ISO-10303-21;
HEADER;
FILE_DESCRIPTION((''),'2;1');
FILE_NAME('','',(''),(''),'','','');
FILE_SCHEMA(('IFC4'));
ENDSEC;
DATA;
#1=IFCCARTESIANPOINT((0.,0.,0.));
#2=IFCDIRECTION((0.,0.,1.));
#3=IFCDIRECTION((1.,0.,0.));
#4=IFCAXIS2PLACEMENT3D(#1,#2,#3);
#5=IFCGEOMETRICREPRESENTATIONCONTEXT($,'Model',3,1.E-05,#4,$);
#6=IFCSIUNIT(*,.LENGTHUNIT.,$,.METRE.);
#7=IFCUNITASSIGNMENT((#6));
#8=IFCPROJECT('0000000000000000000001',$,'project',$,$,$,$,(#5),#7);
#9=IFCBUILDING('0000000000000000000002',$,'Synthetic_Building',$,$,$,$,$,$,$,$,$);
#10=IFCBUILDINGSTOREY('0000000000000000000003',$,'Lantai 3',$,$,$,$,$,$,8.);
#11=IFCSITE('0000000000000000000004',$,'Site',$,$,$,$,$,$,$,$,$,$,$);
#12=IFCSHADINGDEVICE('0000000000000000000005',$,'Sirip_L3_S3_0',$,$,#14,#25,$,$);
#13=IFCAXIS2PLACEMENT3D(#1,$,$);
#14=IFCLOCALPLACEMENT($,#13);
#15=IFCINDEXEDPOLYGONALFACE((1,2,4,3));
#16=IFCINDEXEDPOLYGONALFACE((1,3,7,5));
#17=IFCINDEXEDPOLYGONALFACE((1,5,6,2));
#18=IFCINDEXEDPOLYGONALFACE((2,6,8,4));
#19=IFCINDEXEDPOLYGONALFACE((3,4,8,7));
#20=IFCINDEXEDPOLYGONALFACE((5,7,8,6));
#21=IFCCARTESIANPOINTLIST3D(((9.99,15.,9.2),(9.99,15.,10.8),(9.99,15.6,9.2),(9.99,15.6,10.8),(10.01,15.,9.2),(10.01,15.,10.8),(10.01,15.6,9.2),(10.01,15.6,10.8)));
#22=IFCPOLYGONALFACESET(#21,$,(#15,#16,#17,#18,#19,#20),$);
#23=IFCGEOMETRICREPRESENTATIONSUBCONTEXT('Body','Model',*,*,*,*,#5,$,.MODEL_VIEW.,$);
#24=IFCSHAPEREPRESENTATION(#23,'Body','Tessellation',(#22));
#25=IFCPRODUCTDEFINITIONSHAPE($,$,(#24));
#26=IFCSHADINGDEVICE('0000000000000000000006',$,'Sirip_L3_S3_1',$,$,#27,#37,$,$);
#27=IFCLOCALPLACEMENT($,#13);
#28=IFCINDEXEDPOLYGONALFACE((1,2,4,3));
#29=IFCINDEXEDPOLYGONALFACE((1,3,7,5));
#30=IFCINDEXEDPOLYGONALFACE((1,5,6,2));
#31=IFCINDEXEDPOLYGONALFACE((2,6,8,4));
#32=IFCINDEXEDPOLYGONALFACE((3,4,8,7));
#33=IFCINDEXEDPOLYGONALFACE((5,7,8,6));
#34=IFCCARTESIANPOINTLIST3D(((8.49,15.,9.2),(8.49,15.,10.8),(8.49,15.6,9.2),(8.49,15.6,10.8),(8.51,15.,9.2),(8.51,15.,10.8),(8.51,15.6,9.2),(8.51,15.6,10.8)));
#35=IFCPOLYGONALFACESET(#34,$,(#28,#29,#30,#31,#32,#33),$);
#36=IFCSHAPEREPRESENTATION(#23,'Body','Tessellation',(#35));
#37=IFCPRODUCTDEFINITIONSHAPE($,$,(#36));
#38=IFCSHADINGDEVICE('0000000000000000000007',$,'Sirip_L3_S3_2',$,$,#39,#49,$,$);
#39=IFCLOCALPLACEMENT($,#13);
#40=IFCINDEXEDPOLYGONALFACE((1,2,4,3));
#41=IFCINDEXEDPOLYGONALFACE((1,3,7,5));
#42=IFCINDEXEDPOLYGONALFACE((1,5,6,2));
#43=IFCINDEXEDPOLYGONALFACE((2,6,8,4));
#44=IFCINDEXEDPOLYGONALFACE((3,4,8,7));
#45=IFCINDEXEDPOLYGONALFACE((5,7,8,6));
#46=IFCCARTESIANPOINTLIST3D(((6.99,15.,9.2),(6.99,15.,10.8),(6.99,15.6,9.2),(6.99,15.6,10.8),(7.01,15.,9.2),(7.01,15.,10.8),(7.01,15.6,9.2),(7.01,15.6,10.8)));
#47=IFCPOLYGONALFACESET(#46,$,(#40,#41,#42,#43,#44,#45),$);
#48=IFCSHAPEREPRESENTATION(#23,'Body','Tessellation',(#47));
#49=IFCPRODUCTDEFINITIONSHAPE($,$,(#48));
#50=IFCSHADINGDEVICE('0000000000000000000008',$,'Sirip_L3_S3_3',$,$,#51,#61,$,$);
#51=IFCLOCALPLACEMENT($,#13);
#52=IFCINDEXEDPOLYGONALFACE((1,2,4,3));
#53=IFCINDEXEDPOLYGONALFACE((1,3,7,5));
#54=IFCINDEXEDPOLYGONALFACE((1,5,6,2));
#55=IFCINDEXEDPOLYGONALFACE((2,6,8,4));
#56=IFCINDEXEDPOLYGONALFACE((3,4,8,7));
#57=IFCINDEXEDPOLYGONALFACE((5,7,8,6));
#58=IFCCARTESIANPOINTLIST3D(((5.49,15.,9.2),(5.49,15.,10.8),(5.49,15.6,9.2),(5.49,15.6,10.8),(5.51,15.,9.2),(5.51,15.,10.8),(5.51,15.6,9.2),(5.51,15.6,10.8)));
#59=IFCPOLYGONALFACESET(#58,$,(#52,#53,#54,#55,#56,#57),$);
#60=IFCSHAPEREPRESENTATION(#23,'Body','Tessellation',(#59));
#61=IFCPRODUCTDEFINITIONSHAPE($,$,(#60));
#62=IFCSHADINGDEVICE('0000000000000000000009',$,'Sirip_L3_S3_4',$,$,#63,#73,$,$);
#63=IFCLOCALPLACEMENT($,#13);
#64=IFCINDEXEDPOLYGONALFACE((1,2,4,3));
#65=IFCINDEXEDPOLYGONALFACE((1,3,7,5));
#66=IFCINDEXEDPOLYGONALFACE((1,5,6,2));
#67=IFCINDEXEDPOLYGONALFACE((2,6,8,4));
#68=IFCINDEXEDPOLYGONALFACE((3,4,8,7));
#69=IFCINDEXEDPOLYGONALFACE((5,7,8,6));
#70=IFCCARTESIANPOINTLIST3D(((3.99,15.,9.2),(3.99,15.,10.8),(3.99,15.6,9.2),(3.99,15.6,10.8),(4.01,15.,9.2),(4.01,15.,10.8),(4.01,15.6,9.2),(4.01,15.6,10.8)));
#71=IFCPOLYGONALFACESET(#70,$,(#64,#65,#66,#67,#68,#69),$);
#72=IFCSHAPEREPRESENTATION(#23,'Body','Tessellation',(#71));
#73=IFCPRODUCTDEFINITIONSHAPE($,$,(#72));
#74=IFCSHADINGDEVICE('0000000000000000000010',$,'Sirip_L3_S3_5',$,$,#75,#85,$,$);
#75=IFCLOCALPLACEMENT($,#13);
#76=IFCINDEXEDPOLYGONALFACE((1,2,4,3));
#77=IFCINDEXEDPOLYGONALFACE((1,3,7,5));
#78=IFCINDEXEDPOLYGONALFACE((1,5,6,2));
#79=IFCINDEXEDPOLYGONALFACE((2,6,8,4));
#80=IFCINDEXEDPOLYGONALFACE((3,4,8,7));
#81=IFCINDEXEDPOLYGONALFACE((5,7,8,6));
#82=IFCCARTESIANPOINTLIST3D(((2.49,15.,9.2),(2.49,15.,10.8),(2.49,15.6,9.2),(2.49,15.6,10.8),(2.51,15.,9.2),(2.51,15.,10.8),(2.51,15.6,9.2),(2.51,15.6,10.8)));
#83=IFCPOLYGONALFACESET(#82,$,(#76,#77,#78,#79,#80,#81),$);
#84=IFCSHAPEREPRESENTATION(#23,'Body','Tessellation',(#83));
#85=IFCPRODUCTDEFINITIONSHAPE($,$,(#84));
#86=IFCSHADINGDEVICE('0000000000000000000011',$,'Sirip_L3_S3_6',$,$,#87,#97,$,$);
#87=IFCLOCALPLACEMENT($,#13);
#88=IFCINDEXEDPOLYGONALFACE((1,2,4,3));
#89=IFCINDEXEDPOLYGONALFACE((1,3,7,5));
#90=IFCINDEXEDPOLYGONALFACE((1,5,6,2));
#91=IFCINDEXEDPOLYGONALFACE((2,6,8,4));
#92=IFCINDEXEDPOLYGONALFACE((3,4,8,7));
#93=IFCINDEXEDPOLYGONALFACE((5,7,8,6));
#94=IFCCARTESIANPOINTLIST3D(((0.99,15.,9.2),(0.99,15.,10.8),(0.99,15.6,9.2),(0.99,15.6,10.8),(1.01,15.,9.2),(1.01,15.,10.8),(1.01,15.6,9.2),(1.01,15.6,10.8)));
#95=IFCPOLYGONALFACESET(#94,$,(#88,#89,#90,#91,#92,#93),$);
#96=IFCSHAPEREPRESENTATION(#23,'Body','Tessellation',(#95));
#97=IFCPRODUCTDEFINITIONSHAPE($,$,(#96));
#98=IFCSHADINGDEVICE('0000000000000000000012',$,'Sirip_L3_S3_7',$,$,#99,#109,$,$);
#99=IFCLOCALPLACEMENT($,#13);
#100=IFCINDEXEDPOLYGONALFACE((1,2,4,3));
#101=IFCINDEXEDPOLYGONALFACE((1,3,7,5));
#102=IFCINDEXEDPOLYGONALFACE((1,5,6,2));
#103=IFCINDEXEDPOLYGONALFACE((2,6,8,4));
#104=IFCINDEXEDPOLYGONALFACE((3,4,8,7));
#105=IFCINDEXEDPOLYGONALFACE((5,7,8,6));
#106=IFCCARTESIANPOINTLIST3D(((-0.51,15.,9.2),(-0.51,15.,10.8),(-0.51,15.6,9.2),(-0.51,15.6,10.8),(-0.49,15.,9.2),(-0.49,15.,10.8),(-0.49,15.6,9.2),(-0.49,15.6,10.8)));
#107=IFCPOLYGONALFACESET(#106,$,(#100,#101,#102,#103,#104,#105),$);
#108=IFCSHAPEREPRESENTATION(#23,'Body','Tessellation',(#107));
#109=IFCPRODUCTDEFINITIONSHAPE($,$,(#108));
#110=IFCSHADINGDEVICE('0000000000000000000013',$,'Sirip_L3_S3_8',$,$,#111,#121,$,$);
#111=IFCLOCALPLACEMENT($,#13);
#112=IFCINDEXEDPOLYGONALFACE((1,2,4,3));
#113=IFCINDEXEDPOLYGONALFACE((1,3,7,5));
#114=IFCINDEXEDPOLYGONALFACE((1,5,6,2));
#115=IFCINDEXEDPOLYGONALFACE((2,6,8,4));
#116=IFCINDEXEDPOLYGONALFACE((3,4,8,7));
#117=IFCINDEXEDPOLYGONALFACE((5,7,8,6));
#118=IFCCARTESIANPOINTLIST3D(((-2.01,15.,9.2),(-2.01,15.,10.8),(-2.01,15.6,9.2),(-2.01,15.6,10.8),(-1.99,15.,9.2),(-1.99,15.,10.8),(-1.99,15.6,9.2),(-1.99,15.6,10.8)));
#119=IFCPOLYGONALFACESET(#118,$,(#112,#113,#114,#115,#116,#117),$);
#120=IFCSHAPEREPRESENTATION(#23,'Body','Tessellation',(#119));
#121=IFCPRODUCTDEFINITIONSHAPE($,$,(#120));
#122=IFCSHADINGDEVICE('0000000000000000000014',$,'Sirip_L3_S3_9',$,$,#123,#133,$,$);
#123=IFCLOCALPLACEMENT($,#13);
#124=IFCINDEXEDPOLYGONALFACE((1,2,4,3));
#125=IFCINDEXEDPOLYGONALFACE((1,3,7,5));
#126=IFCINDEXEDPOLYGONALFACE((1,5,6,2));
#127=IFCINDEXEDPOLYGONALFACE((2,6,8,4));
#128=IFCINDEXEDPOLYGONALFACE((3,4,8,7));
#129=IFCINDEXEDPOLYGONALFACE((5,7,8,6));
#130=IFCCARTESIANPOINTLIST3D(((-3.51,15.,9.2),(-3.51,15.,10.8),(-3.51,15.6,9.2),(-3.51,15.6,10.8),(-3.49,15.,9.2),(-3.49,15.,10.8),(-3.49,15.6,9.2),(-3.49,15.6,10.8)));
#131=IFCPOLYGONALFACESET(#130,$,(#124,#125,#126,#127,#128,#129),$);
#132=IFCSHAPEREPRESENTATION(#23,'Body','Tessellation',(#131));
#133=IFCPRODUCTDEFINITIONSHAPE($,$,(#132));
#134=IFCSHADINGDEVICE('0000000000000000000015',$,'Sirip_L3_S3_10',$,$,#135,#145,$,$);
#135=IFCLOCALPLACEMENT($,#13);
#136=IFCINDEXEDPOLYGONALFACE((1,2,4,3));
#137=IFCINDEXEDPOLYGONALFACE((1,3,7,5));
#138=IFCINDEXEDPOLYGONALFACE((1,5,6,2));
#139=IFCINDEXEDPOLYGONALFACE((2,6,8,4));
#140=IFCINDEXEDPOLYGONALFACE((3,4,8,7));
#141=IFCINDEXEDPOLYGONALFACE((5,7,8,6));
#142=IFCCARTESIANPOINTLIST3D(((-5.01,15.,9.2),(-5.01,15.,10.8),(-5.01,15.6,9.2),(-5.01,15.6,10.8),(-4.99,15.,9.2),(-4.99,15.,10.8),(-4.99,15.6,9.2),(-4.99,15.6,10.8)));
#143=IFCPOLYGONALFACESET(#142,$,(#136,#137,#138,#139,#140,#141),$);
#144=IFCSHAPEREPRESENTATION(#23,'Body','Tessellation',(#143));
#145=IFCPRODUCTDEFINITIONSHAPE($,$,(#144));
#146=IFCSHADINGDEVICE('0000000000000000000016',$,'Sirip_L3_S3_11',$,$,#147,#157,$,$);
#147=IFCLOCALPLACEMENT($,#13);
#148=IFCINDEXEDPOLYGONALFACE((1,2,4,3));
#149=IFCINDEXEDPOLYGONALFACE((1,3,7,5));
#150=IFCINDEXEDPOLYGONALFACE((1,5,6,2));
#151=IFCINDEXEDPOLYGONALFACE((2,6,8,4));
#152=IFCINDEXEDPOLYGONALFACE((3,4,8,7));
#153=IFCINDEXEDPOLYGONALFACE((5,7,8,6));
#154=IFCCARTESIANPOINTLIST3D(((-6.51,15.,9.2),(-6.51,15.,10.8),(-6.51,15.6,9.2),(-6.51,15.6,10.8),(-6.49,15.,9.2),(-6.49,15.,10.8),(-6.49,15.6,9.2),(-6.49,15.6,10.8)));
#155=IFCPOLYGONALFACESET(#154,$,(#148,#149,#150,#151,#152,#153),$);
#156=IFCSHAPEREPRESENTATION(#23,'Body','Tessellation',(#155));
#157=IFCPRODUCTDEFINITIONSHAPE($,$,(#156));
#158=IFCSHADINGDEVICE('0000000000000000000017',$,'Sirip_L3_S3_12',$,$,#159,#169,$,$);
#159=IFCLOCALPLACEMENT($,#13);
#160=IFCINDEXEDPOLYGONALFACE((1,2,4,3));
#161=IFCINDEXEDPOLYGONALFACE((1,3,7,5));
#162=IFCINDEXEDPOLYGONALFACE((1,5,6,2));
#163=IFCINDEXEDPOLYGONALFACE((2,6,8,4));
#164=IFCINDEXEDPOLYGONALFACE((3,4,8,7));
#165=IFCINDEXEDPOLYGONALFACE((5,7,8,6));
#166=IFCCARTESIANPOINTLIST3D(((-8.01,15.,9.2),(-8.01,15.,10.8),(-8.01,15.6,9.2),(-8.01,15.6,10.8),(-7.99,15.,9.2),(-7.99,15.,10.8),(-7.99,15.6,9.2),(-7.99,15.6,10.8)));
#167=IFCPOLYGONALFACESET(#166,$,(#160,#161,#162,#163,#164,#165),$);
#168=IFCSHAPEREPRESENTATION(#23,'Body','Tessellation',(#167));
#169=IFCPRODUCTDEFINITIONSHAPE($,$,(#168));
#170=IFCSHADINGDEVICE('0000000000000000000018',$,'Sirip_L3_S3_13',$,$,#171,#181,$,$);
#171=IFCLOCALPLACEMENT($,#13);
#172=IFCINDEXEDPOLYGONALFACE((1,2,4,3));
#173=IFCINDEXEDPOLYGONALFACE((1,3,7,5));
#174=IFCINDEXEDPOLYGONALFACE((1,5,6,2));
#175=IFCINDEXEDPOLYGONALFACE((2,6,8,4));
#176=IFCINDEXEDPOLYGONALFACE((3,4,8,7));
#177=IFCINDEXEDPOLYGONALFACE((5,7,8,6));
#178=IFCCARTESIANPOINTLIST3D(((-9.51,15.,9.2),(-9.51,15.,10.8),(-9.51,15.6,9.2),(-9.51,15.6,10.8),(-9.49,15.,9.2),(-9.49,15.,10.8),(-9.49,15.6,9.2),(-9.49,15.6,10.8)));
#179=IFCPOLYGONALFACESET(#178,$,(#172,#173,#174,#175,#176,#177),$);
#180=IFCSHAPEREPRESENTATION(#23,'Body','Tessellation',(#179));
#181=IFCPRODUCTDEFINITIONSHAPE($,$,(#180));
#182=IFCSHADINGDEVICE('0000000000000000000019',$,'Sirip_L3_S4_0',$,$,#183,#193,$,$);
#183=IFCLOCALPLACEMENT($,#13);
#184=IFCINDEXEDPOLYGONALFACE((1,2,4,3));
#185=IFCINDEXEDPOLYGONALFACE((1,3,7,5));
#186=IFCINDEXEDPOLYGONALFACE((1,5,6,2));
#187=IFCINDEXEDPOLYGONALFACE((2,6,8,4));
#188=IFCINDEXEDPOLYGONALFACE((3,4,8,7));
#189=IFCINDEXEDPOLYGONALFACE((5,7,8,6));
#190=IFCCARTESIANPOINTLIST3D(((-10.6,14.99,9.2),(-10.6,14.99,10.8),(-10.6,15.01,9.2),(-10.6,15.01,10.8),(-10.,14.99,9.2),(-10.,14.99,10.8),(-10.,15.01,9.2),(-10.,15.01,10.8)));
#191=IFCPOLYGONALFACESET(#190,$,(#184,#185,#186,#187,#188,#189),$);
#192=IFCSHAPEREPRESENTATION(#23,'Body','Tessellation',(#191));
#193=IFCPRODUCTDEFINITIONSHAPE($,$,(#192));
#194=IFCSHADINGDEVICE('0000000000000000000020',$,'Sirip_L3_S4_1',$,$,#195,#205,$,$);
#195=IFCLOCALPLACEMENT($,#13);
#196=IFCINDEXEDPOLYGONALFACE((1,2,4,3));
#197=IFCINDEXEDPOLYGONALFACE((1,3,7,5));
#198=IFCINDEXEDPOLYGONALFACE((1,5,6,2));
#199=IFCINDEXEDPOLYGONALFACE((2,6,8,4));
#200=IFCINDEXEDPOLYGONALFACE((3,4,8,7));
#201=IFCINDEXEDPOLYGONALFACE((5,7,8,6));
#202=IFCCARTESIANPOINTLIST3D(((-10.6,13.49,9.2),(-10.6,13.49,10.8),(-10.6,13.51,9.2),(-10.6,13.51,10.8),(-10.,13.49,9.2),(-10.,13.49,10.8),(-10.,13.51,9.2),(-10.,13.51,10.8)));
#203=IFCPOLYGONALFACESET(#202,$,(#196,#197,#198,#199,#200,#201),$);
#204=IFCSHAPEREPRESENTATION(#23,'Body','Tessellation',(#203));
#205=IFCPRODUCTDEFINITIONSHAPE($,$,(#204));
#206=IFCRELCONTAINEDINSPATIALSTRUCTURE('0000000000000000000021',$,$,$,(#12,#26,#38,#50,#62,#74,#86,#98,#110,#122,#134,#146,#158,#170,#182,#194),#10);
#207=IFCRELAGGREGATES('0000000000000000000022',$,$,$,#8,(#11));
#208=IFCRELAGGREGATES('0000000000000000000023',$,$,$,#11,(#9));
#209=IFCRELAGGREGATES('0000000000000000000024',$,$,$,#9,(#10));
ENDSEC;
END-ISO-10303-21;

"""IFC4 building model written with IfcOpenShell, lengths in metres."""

from ifc_helpers import new_model, si_unit, frame, origin_with_axes, place, context, subcontext, project, spatial, polyline, outline, extrude, element, save


model = new_model("IFC4")

# Units and contexts
model_context = context("Model", 3, precision=1e-05, world=origin_with_axes())
body_context = subcontext(model_context, "Body", "Model", "MODEL_VIEW")
ifc_project = project(units=[si_unit("LENGTHUNIT", "METRE")], contexts=[model_context])

# Site, building, storey
site = spatial("IfcSite", under=ifc_project, Name="Site")
building = spatial("IfcBuilding", under=site, Name="Synthetic_Building")
storey = spatial("IfcBuildingStorey", under=building, Name="Lantai 3", Elevation=8.0)

# Shading devices
shading_device_1_placement = place(None, origin_with_axes())
element("IfcShadingDevice", 1, at=shading_device_1_placement, inside=storey, Name="Sirip_L3_S3_0", context=body_context, shape_type="SweptSolid", body=[
    extrude(outline(polyline([(10.01, 15.0), (9.99, 15.0), (9.99, 15.6), (10.01, 15.6), (10.01, 15.0)])), frame((0.0, 0.0, 9.2), z_axis=(0.0, 0.0, 1.0), x_axis=(1.0, 0.0, 0.0)), (0.0, 0.0, 1.0), 1.6),
])
shading_device_2_placement = place(None, origin_with_axes())
element("IfcShadingDevice", 2, at=shading_device_2_placement, inside=storey, Name="Sirip_L3_S3_1", context=body_context, shape_type="SweptSolid", body=[
    extrude(outline(polyline([(8.51, 15.0), (8.49, 15.0), (8.49, 15.6), (8.51, 15.6), (8.51, 15.0)])), frame((0.0, 0.0, 9.2), z_axis=(0.0, 0.0, 1.0), x_axis=(1.0, 0.0, 0.0)), (0.0, 0.0, 1.0), 1.6),
])
shading_device_3_placement = place(None, origin_with_axes())
element("IfcShadingDevice", 3, at=shading_device_3_placement, inside=storey, Name="Sirip_L3_S3_2", context=body_context, shape_type="SweptSolid", body=[
    extrude(outline(polyline([(7.01, 15.0), (6.99, 15.0), (6.99, 15.6), (7.01, 15.6), (7.01, 15.0)])), frame((0.0, 0.0, 9.2), z_axis=(0.0, 0.0, 1.0), x_axis=(1.0, 0.0, 0.0)), (0.0, 0.0, 1.0), 1.6),
])
shading_device_4_placement = place(None, origin_with_axes())
element("IfcShadingDevice", 4, at=shading_device_4_placement, inside=storey, Name="Sirip_L3_S3_3", context=body_context, shape_type="SweptSolid", body=[
    extrude(outline(polyline([(5.51, 15.0), (5.49, 15.0), (5.49, 15.6), (5.51, 15.6), (5.51, 15.0)])), frame((0.0, 0.0, 9.2), z_axis=(0.0, 0.0, 1.0), x_axis=(1.0, 0.0, 0.0)), (0.0, 0.0, 1.0), 1.6),
])
shading_device_5_placement = place(None, origin_with_axes())
element("IfcShadingDevice", 5, at=shading_device_5_placement, inside=storey, Name="Sirip_L3_S3_4", context=body_context, shape_type="SweptSolid", body=[
    extrude(outline(polyline([(4.01, 15.0), (3.99, 15.0), (3.99, 15.6), (4.01, 15.6), (4.01, 15.0)])), frame((0.0, 0.0, 9.2), z_axis=(0.0, 0.0, 1.0), x_axis=(1.0, 0.0, 0.0)), (0.0, 0.0, 1.0), 1.6),
])
shading_device_6_placement = place(None, origin_with_axes())
element("IfcShadingDevice", 6, at=shading_device_6_placement, inside=storey, Name="Sirip_L3_S3_5", context=body_context, shape_type="SweptSolid", body=[
    extrude(outline(polyline([(2.51, 15.0), (2.49, 15.0), (2.49, 15.6), (2.51, 15.6), (2.51, 15.0)])), frame((0.0, 0.0, 9.2), z_axis=(0.0, 0.0, 1.0), x_axis=(1.0, 0.0, 0.0)), (0.0, 0.0, 1.0), 1.6),
])
shading_device_7_placement = place(None, origin_with_axes())
element("IfcShadingDevice", 7, at=shading_device_7_placement, inside=storey, Name="Sirip_L3_S3_6", context=body_context, shape_type="SweptSolid", body=[
    extrude(outline(polyline([(1.01, 15.0), (0.99, 15.0), (0.99, 15.6), (1.01, 15.6), (1.01, 15.0)])), frame((0.0, 0.0, 9.2), z_axis=(0.0, 0.0, 1.0), x_axis=(1.0, 0.0, 0.0)), (0.0, 0.0, 1.0), 1.6),
])
shading_device_8_placement = place(None, origin_with_axes())
element("IfcShadingDevice", 8, at=shading_device_8_placement, inside=storey, Name="Sirip_L3_S3_7", context=body_context, shape_type="SweptSolid", body=[
    extrude(outline(polyline([(-0.49, 15.0), (-0.51, 15.0), (-0.51, 15.6), (-0.49, 15.6), (-0.49, 15.0)])), frame((0.0, 0.0, 9.2), z_axis=(0.0, 0.0, 1.0), x_axis=(1.0, 0.0, 0.0)), (0.0, 0.0, 1.0), 1.6),
])
shading_device_9_placement = place(None, origin_with_axes())
element("IfcShadingDevice", 9, at=shading_device_9_placement, inside=storey, Name="Sirip_L3_S3_8", context=body_context, shape_type="SweptSolid", body=[
    extrude(outline(polyline([(-1.99, 15.0), (-2.01, 15.0), (-2.01, 15.6), (-1.99, 15.6), (-1.99, 15.0)])), frame((0.0, 0.0, 9.2), z_axis=(0.0, 0.0, 1.0), x_axis=(1.0, 0.0, 0.0)), (0.0, 0.0, 1.0), 1.6),
])
shading_device_10_placement = place(None, origin_with_axes())
element("IfcShadingDevice", 10, at=shading_device_10_placement, inside=storey, Name="Sirip_L3_S3_9", context=body_context, shape_type="SweptSolid", body=[
    extrude(outline(polyline([(-3.49, 15.0), (-3.51, 15.0), (-3.51, 15.6), (-3.49, 15.6), (-3.49, 15.0)])), frame((0.0, 0.0, 9.2), z_axis=(0.0, 0.0, 1.0), x_axis=(1.0, 0.0, 0.0)), (0.0, 0.0, 1.0), 1.6),
])
shading_device_11_placement = place(None, origin_with_axes())
element("IfcShadingDevice", 11, at=shading_device_11_placement, inside=storey, Name="Sirip_L3_S3_10", context=body_context, shape_type="SweptSolid", body=[
    extrude(outline(polyline([(-4.99, 15.0), (-5.01, 15.0), (-5.01, 15.6), (-4.99, 15.6), (-4.99, 15.0)])), frame((0.0, 0.0, 9.2), z_axis=(0.0, 0.0, 1.0), x_axis=(1.0, 0.0, 0.0)), (0.0, 0.0, 1.0), 1.6),
])
shading_device_12_placement = place(None, origin_with_axes())
element("IfcShadingDevice", 12, at=shading_device_12_placement, inside=storey, Name="Sirip_L3_S3_11", context=body_context, shape_type="SweptSolid", body=[
    extrude(outline(polyline([(-6.49, 15.0), (-6.51, 15.0), (-6.51, 15.6), (-6.49, 15.6), (-6.49, 15.0)])), frame((0.0, 0.0, 9.2), z_axis=(0.0, 0.0, 1.0), x_axis=(1.0, 0.0, 0.0)), (0.0, 0.0, 1.0), 1.6),
])
shading_device_13_placement = place(None, origin_with_axes())
element("IfcShadingDevice", 13, at=shading_device_13_placement, inside=storey, Name="Sirip_L3_S3_12", context=body_context, shape_type="SweptSolid", body=[
    extrude(outline(polyline([(-7.99, 15.0), (-8.01, 15.0), (-8.01, 15.6), (-7.99, 15.6), (-7.99, 15.0)])), frame((0.0, 0.0, 9.2), z_axis=(0.0, 0.0, 1.0), x_axis=(1.0, 0.0, 0.0)), (0.0, 0.0, 1.0), 1.6),
])
shading_device_14_placement = place(None, origin_with_axes())
element("IfcShadingDevice", 14, at=shading_device_14_placement, inside=storey, Name="Sirip_L3_S3_13", context=body_context, shape_type="SweptSolid", body=[
    extrude(outline(polyline([(-9.49, 15.0), (-9.51, 15.0), (-9.51, 15.6), (-9.49, 15.6), (-9.49, 15.0)])), frame((0.0, 0.0, 9.2), z_axis=(0.0, 0.0, 1.0), x_axis=(1.0, 0.0, 0.0)), (0.0, 0.0, 1.0), 1.6),
])
shading_device_15_placement = place(None, origin_with_axes())
element("IfcShadingDevice", 15, at=shading_device_15_placement, inside=storey, Name="Sirip_L3_S4_0", context=body_context, shape_type="SweptSolid", body=[
    extrude(outline(polyline([(-10.0, 15.01), (-10.0, 14.99), (-10.6, 14.99), (-10.6, 15.01), (-10.0, 15.01)])), frame((0.0, 0.0, 9.2), z_axis=(0.0, 0.0, 1.0), x_axis=(1.0, 0.0, 0.0)), (0.0, 0.0, 1.0), 1.6),
])
shading_device_16_placement = place(None, origin_with_axes())
element("IfcShadingDevice", 16, at=shading_device_16_placement, inside=storey, Name="Sirip_L3_S4_1", context=body_context, shape_type="SweptSolid", body=[
    extrude(outline(polyline([(-10.0, 13.51), (-10.0, 13.49), (-10.6, 13.49), (-10.6, 13.51), (-10.0, 13.51)])), frame((0.0, 0.0, 9.2), z_axis=(0.0, 0.0, 1.0), x_axis=(1.0, 0.0, 0.0)), (0.0, 0.0, 1.0), 1.6),
])

save(model, "model.ifc")
